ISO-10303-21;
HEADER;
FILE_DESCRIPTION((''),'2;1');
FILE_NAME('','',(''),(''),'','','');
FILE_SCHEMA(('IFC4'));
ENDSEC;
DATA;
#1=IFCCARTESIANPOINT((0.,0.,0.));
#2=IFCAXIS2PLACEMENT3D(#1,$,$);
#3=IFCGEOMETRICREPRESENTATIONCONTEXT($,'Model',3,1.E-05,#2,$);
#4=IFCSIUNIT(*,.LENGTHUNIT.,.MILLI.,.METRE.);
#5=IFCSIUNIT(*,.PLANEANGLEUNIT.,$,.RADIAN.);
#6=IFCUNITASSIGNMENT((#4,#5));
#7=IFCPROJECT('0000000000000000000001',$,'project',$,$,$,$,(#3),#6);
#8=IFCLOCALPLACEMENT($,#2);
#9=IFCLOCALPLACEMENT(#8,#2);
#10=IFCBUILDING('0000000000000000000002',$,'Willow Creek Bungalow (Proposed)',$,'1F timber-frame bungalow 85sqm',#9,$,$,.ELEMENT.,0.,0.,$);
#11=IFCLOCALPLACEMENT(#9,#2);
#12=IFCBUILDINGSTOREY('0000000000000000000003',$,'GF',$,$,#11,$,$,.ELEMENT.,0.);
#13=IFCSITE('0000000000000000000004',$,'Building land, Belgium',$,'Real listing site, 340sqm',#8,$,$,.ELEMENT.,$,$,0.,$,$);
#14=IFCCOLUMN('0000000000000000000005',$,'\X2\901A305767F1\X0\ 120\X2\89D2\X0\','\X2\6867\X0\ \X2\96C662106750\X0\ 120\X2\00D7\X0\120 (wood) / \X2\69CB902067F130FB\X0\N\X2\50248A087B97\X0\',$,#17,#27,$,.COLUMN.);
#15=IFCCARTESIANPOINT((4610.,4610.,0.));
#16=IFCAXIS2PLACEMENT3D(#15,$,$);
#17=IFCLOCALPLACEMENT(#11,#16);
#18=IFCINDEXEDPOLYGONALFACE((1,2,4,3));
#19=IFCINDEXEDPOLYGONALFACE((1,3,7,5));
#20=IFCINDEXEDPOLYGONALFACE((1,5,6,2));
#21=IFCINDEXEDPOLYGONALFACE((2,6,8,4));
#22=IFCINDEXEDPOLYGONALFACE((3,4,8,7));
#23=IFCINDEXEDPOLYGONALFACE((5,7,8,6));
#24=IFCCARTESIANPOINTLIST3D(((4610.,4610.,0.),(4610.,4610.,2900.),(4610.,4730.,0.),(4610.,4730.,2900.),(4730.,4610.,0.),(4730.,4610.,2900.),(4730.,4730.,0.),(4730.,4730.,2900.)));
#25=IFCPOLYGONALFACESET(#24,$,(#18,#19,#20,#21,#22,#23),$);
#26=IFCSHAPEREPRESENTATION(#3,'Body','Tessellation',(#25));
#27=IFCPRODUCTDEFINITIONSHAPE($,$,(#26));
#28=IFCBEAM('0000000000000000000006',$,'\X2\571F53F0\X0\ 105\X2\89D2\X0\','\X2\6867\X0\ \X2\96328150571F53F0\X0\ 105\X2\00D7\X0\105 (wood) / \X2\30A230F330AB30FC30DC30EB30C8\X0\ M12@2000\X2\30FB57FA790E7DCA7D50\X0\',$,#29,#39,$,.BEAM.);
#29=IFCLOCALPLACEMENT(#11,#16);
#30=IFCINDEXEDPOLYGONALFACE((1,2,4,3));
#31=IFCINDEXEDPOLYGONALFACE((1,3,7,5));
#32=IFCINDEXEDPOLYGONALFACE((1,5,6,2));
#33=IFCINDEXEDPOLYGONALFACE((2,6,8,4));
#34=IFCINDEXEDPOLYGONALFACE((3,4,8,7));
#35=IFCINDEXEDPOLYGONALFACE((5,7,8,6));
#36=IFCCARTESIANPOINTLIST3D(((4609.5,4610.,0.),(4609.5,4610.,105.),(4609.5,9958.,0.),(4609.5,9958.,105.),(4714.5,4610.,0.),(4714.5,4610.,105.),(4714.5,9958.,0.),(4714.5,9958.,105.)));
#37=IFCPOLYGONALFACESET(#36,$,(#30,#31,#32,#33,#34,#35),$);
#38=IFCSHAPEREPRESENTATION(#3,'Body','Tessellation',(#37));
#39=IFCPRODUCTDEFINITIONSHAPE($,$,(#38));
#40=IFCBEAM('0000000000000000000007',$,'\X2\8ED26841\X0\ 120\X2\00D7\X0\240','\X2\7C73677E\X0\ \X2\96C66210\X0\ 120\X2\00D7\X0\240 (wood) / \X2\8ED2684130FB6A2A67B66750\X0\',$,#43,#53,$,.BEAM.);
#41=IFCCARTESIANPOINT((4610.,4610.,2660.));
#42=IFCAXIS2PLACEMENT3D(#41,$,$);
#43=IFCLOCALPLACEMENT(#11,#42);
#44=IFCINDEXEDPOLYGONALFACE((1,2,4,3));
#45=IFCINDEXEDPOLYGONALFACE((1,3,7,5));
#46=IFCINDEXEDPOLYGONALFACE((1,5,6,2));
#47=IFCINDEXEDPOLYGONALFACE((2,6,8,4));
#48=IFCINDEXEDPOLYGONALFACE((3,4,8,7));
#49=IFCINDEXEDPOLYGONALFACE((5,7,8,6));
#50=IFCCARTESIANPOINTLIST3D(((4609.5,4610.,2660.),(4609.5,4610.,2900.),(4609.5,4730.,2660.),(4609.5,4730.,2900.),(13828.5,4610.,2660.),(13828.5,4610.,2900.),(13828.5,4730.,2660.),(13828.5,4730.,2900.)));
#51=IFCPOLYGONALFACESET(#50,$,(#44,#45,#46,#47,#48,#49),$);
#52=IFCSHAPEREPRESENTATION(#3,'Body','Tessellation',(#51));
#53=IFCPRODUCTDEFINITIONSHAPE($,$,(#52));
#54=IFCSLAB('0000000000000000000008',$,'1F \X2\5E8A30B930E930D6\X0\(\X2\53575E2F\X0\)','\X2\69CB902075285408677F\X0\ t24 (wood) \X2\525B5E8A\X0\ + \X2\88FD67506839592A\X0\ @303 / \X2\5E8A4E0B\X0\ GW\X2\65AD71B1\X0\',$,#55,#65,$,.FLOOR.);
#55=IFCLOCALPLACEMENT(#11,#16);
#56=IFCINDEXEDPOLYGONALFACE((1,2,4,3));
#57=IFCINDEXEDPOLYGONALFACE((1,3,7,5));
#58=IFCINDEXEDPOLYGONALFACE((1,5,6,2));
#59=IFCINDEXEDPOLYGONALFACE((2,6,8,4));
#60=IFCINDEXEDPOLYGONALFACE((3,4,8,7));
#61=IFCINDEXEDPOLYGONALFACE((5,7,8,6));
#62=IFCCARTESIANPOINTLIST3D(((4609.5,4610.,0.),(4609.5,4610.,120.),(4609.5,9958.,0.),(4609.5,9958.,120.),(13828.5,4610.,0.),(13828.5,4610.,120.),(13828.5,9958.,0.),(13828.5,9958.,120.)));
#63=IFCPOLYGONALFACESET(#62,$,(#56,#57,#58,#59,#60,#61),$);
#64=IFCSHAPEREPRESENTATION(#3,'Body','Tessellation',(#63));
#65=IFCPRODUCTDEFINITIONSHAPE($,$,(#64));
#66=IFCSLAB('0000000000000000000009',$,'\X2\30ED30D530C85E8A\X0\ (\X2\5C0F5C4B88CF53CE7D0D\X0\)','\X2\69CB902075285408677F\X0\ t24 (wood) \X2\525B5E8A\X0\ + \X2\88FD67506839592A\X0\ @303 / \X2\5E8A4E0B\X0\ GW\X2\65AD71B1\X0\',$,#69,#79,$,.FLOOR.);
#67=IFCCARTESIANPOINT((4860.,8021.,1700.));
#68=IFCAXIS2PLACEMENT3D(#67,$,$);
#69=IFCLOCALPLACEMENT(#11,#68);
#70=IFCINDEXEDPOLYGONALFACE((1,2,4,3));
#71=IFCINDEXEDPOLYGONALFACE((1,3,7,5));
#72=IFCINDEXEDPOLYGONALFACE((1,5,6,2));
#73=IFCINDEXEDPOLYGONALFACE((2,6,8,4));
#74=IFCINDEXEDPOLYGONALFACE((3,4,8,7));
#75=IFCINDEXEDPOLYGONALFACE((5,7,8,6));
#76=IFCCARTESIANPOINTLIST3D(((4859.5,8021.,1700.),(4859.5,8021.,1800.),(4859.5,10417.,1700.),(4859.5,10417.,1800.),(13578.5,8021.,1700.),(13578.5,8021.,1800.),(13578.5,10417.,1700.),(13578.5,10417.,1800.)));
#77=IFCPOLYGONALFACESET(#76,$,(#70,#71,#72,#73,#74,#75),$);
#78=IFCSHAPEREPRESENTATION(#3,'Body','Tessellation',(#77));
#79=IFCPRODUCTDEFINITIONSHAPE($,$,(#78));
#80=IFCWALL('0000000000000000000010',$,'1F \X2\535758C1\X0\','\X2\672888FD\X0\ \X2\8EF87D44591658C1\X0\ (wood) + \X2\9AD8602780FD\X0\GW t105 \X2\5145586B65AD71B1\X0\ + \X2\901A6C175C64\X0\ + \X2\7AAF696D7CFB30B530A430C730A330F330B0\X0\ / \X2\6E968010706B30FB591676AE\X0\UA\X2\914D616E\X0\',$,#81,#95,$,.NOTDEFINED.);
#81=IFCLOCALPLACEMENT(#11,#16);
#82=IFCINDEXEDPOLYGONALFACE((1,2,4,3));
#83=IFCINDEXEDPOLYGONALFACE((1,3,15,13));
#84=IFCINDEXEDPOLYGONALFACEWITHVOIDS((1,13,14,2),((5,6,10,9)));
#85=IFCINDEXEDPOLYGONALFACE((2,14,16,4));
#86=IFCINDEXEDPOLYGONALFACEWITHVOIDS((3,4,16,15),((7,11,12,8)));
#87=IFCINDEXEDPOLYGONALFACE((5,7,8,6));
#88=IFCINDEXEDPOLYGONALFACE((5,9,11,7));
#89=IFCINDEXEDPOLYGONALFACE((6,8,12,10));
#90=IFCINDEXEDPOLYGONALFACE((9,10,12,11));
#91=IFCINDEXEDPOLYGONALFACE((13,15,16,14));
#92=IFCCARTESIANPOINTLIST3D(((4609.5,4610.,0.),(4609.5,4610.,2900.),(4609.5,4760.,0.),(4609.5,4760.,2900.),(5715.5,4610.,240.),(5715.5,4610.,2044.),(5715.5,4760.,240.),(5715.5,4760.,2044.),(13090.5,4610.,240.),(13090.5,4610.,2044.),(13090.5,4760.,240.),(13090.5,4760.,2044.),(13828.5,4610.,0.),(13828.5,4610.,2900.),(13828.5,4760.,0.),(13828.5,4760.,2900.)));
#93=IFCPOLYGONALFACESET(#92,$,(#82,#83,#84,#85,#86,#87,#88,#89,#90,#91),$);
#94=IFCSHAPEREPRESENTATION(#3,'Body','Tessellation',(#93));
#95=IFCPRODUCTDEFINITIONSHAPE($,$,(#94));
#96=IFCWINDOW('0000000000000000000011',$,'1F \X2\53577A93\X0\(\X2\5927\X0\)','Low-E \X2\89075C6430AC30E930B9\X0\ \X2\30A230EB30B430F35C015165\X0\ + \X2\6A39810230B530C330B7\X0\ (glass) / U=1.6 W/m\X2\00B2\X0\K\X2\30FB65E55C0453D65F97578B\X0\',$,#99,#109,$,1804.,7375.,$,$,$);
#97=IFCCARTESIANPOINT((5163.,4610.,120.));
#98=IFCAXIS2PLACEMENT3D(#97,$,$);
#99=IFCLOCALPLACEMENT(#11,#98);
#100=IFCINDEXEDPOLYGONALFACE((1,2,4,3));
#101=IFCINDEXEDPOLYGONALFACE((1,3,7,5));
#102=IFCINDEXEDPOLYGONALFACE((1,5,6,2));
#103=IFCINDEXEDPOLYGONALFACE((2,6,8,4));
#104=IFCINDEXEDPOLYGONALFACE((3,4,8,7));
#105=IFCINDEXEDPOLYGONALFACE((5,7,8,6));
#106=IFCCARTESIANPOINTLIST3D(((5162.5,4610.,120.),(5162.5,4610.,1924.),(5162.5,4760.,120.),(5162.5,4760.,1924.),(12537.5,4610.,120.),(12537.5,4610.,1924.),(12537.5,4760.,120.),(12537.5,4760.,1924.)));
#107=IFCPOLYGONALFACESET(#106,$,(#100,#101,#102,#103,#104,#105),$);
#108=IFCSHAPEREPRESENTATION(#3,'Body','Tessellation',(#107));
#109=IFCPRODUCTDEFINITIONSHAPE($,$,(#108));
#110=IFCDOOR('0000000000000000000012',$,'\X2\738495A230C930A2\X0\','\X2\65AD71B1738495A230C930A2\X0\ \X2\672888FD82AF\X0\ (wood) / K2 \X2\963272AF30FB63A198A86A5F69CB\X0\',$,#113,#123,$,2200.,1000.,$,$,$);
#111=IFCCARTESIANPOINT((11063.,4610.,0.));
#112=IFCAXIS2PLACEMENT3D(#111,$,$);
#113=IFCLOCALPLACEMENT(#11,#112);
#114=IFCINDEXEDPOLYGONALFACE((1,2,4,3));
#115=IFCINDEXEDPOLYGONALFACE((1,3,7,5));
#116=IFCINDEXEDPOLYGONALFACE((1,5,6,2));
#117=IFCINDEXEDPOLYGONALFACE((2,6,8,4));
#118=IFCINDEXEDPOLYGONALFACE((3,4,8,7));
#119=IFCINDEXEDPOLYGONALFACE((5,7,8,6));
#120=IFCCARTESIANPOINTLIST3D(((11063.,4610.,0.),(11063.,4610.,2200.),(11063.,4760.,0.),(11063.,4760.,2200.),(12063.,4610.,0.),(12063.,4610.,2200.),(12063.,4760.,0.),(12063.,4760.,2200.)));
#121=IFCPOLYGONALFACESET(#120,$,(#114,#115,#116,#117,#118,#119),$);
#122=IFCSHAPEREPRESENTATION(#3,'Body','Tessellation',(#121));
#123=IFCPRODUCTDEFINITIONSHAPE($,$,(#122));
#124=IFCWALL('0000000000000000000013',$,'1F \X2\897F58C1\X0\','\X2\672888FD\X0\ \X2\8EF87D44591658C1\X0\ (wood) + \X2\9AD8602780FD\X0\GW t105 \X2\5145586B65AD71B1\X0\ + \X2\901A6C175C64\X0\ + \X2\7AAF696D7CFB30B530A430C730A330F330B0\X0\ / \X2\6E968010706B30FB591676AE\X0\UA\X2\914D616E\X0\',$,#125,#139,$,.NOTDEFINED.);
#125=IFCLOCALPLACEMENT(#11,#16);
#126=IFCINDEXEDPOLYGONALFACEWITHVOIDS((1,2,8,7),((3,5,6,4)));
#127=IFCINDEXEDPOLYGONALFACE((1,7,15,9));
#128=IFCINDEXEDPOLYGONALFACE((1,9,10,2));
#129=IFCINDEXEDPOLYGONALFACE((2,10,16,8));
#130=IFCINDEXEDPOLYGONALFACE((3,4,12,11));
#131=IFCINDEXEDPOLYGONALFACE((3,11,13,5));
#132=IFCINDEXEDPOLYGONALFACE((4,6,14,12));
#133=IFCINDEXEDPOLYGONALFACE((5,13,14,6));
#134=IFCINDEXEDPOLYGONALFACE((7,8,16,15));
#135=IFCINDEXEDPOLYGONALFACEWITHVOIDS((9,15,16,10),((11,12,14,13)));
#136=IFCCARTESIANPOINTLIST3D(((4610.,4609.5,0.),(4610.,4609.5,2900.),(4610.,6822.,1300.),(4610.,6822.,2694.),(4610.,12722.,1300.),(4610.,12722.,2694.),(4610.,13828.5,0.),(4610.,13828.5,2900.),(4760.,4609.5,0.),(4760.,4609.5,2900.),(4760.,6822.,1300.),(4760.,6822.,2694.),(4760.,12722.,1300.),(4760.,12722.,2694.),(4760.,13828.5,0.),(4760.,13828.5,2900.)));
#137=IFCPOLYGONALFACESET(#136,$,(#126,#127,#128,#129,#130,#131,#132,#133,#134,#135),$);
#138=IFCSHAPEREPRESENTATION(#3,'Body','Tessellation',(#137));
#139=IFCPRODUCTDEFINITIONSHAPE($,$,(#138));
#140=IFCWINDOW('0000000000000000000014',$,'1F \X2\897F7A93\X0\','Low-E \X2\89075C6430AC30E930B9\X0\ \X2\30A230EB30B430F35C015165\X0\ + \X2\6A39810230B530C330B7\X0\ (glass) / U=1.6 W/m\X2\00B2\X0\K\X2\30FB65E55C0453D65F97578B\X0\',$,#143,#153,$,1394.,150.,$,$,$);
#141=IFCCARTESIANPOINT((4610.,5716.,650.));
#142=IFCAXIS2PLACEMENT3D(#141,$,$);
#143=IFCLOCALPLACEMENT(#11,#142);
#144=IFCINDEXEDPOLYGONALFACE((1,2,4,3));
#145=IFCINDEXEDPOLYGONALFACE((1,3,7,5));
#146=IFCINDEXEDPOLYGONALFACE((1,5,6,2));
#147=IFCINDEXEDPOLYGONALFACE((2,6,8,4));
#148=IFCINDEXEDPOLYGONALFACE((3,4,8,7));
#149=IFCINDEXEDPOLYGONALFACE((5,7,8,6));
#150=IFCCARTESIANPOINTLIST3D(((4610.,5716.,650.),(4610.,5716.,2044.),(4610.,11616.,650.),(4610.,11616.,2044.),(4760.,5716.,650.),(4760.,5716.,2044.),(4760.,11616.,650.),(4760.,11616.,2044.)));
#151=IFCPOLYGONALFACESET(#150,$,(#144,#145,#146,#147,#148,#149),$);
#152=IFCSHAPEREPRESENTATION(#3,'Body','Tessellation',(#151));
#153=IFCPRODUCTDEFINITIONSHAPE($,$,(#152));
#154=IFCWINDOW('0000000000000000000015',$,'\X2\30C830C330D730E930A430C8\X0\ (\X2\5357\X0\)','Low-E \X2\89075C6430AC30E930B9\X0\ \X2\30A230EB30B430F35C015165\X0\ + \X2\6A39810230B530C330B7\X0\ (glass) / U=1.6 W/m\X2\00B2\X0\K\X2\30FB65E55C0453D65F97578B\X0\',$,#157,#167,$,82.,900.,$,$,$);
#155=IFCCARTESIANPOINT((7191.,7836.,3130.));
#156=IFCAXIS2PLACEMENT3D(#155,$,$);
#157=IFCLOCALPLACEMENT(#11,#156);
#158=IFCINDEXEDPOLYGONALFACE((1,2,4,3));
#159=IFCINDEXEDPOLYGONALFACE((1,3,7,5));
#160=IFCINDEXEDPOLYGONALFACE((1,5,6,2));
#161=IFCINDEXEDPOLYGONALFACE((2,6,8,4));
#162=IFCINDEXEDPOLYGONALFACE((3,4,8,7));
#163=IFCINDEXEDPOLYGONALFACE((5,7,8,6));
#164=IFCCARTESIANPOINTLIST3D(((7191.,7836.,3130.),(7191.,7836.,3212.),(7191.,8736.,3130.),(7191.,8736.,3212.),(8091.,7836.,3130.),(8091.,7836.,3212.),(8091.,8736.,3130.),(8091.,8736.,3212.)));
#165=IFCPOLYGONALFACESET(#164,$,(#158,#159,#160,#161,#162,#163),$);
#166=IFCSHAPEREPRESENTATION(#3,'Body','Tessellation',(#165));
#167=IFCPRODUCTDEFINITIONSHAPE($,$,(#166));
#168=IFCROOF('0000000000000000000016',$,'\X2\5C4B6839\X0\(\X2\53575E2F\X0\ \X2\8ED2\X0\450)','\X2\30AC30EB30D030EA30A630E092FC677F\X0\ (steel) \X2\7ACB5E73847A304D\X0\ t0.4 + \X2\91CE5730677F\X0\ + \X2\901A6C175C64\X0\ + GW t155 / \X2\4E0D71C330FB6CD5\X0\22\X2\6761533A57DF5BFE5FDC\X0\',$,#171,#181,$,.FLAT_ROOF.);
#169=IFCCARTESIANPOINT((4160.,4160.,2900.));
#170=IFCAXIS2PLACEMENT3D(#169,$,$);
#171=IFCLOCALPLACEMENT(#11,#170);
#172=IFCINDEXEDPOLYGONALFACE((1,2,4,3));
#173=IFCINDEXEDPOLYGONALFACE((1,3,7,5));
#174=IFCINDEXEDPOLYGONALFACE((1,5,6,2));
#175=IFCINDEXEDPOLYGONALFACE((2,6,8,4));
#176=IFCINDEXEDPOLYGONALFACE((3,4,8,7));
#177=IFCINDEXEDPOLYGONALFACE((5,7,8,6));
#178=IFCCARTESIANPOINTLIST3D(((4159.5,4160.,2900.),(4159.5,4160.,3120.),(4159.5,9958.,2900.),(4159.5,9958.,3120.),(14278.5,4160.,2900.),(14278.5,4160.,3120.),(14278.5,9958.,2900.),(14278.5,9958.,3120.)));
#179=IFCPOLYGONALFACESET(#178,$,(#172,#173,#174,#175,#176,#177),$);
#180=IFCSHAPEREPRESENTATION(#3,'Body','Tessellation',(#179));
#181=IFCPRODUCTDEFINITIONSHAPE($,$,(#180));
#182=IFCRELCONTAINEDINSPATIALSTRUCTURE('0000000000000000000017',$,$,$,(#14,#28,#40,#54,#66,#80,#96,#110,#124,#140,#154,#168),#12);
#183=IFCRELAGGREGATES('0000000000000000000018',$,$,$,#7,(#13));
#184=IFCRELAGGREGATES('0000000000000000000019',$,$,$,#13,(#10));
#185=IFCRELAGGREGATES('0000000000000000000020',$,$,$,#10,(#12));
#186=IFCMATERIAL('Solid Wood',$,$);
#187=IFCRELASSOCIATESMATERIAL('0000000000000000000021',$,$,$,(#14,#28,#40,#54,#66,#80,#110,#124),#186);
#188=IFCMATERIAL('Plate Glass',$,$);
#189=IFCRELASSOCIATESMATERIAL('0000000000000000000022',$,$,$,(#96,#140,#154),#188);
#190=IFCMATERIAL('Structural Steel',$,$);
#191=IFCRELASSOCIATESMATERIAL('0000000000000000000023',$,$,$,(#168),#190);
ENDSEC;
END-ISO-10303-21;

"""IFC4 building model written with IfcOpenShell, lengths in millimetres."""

from ifc_helpers import new_model, si_unit, frame, frame_2d, origin, place, context, project, spatial, rectangle, extrude, material, element, fill, save


model = new_model("IFC4")

# Units and contexts
model_context = context("Model", 3, precision=1e-05, world=origin())
ifc_project = project(units=[si_unit("LENGTHUNIT", "METRE", prefix="MILLI"), si_unit("PLANEANGLEUNIT", "RADIAN")], contexts=[model_context])

# Site, building, storey
site_placement = place(None, origin())
site = spatial("IfcSite", under=ifc_project, at=site_placement, Name="Building land, Belgium", ObjectType="Real listing site, 340sqm", CompositionType="ELEMENT", RefElevation=0.0)
building_placement = place(site_placement, origin())
building = spatial("IfcBuilding", under=site, at=building_placement, Name="Willow Creek Bungalow (Proposed)", ObjectType="1F timber-frame bungalow 85sqm", CompositionType="ELEMENT", ElevationOfRefHeight=0.0, ElevationOfTerrain=0.0)
storey_placement = place(building_placement, origin())
storey = spatial("IfcBuildingStorey", under=building, at=storey_placement, Name="GF", CompositionType="ELEMENT", Elevation=0.0)

# Column
ifc_material_1 = material(Name="Solid Wood")
column_1_placement = place(storey_placement, frame((4610.0, 4610.0, 0.0)))
element("IfcColumn", 1, at=column_1_placement, inside=storey, material=ifc_material_1, Name="通し柱 120角", Description="桧 集成材 120×120 (wood) / 構造柱・N値計算", PredefinedType="COLUMN", context=model_context, shape_type="SweptSolid", body=[
    extrude(rectangle(XDim=120.0, YDim=120.0, at=frame_2d((60.0, 60.0))), frame((4610.0, 4610.0, 0.0)), (0.0, 0.0, 1.0), 2900.0),
])

# Beams
beam_1_placement = place(storey_placement, frame((4610.0, 4610.0, 0.0)))
element("IfcBeam", 2, at=beam_1_placement, inside=storey, material=ifc_material_1, Name="土台 105角", Description="桧 防腐土台 105×105 (wood) / アンカーボルト M12@2000・基礎緊結", PredefinedType="BEAM", context=model_context, shape_type="SweptSolid", body=[
    extrude(rectangle(XDim=105.0, YDim=5348.0, at=frame_2d((52.0, 2674.0))), frame((4610.0, 4610.0, 0.0)), (0.0, 0.0, 1.0), 105.0),
])
beam_2_placement = place(storey_placement, frame((4610.0, 4610.0, 2660.0)))
element("IfcBeam", 3, at=beam_2_placement, inside=storey, material=ifc_material_1, Name="軒桁 120×240", Description="米松 集成 120×240 (wood) / 軒桁・横架材", PredefinedType="BEAM", context=model_context, shape_type="SweptSolid", body=[
    extrude(rectangle(XDim=9219.0, YDim=120.0, at=frame_2d((4609.0, 60.0))), frame((4610.0, 4610.0, 2660.0)), (0.0, 0.0, 1.0), 240.0),
])

# Slabs
slab_1_placement = place(storey_placement, frame((4610.0, 4610.0, 0.0)))
element("IfcSlab", 4, at=slab_1_placement, inside=storey, material=ifc_material_1, Name="1F 床スラブ(南帯)", Description="構造用合板 t24 (wood) 剛床 + 製材根太 @303 / 床下 GW断熱", PredefinedType="FLOOR", context=model_context, shape_type="SweptSolid", body=[
    extrude(rectangle(XDim=9219.0, YDim=5348.0, at=frame_2d((4609.0, 2674.0))), frame((4610.0, 4610.0, 0.0)), (0.0, 0.0, 1.0), 120.0),
])
slab_2_placement = place(storey_placement, frame((4860.0, 8021.0, 1700.0)))
element("IfcSlab", 5, at=slab_2_placement, inside=storey, material=ifc_material_1, Name="ロフト床 (小屋裏収納)", Description="構造用合板 t24 (wood) 剛床 + 製材根太 @303 / 床下 GW断熱", PredefinedType="FLOOR", context=model_context, shape_type="SweptSolid", body=[
    extrude(rectangle(XDim=8719.0, YDim=2396.0, at=frame_2d((4359.0, 1198.0))), frame((4860.0, 8021.0, 1700.0)), (0.0, 0.0, 1.0), 100.0),
])

# Wall, openings, window, door
wall_1_placement = place(storey_placement, frame((4610.0, 4610.0, 0.0)))
wall_1 = element("IfcWall", 6, at=wall_1_placement, inside=storey, material=ifc_material_1, Name="1F 南壁", Description="木製 軸組外壁 (wood) + 高性能GW t105 充填断熱 + 通気層 + 窯業系サイディング / 準耐火・外皮UA配慮", PredefinedType="NOTDEFINED", context=model_context, shape_type="SweptSolid", body=[
    extrude(rectangle(XDim=9219.0, YDim=150.0, at=frame_2d((4609.0, 75.0))), frame((4610.0, 4610.0, 0.0)), (0.0, 0.0, 1.0), 2900.0),
])
opening_1_placement = place(storey_placement, frame((5163.0, 4610.0, 120.0)))
opening_1 = element("IfcOpeningElement", 7, at=opening_1_placement, cuts=wall_1, PredefinedType="NOTDEFINED", context=model_context, shape_type="SweptSolid", body=[
    extrude(rectangle(XDim=7375.0, YDim=150.0, at=frame_2d((3687.0, 75.0))), frame((5163.0, 4610.0, 120.0)), (0.0, 0.0, 1.0), 1804.0),
])
opening_2_placement = place(storey_placement, frame((11063.0, 4610.0, 0.0)))
opening_2 = element("IfcOpeningElement", 8, at=opening_2_placement, cuts=wall_1, PredefinedType="NOTDEFINED", context=model_context, shape_type="SweptSolid", body=[
    extrude(rectangle(XDim=1000.0, YDim=150.0, at=frame_2d((500.0, 75.0))), frame((11063.0, 4610.0, 0.0)), (0.0, 0.0, 1.0), 2200.0),
])
ifc_material_2 = material(Name="Plate Glass")
window_1_placement = place(storey_placement, frame((5163.0, 4610.0, 120.0)))
window_1 = element("IfcWindow", 9, at=window_1_placement, inside=storey, material=ifc_material_2, Name="1F 南窓(大)", Description="Low-E 複層ガラス アルゴン封入 + 樹脂サッシ (glass) / U=1.6 W/m²K・日射取得型", OverallHeight=1804.0, OverallWidth=7375.0, context=model_context, shape_type="SweptSolid", body=[
    extrude(rectangle(XDim=7375.0, YDim=150.0, at=frame_2d((3687.0, 75.0))), frame((5163.0, 4610.0, 120.0)), (0.0, 0.0, 1.0), 1804.0),
])
fill(opening_1, window_1)
door_1_placement = place(storey_placement, frame((11063.0, 4610.0, 0.0)))
door_1 = element("IfcDoor", 10, at=door_1_placement, inside=storey, material=ifc_material_1, Name="玄関ドア", Description="断熱玄関ドア 木製芯 (wood) / K2 防犯・採風機構", OverallHeight=2200.0, OverallWidth=1000.0, context=model_context, shape_type="SweptSolid", body=[
    extrude(rectangle(XDim=1000.0, YDim=150.0, at=frame_2d((500.0, 75.0))), frame((11063.0, 4610.0, 0.0)), (0.0, 0.0, 1.0), 2200.0),
])
fill(opening_2, door_1)

# Wall, opening, window
wall_2_placement = place(storey_placement, frame((4610.0, 4610.0, 0.0)))
wall_2 = element("IfcWall", 11, at=wall_2_placement, inside=storey, material=ifc_material_1, Name="1F 西壁", Description="木製 軸組外壁 (wood) + 高性能GW t105 充填断熱 + 通気層 + 窯業系サイディング / 準耐火・外皮UA配慮", PredefinedType="NOTDEFINED", context=model_context, shape_type="SweptSolid", body=[
    extrude(rectangle(XDim=150.0, YDim=9219.0, at=frame_2d((75.0, 4609.0))), frame((4610.0, 4610.0, 0.0)), (0.0, 0.0, 1.0), 2900.0),
])
opening_3_placement = place(storey_placement, frame((4610.0, 5716.0, 650.0)))
opening_3 = element("IfcOpeningElement", 12, at=opening_3_placement, cuts=wall_2, PredefinedType="NOTDEFINED", context=model_context, shape_type="SweptSolid", body=[
    extrude(rectangle(XDim=150.0, YDim=5900.0, at=frame_2d((75.0, 2950.0))), frame((4610.0, 5716.0, 650.0)), (0.0, 0.0, 1.0), 1394.0),
])
window_2_placement = place(storey_placement, frame((4610.0, 5716.0, 650.0)))
window_2 = element("IfcWindow", 13, at=window_2_placement, inside=storey, material=ifc_material_2, Name="1F 西窓", Description="Low-E 複層ガラス アルゴン封入 + 樹脂サッシ (glass) / U=1.6 W/m²K・日射取得型", OverallHeight=1394.0, OverallWidth=150.0, context=model_context, shape_type="SweptSolid", body=[
    extrude(rectangle(XDim=150.0, YDim=5900.0, at=frame_2d((75.0, 2950.0))), frame((4610.0, 5716.0, 650.0)), (0.0, 0.0, 1.0), 1394.0),
])
fill(opening_3, window_2)

# Window
window_3_placement = place(storey_placement, frame((7191.0, 7836.0, 3130.0)))
element("IfcWindow", 14, at=window_3_placement, inside=storey, material=ifc_material_2, Name="トップライト (南)", Description="Low-E 複層ガラス アルゴン封入 + 樹脂サッシ (glass) / U=1.6 W/m²K・日射取得型", OverallHeight=82.0, OverallWidth=900.0, context=model_context, shape_type="SweptSolid", body=[
    extrude(rectangle(XDim=900.0, YDim=900.0, at=frame_2d((450.0, 450.0))), frame((7191.0, 7836.0, 3130.0)), (0.0, 0.0, 1.0), 82.0),
])

# Roof
ifc_material_3 = material(Name="Structural Steel")
roof_placement = place(storey_placement, frame((4160.0, 4160.0, 2900.0)))
element("IfcRoof", 15, at=roof_placement, inside=storey, material=ifc_material_3, Name="屋根(南帯 軒450)", Description="ガルバリウム鋼板 (steel) 立平葺き t0.4 + 野地板 + 通気層 + GW t155 / 不燃・法22条区域対応", PredefinedType="FLAT_ROOF", context=model_context, shape_type="SweptSolid", body=[
    extrude(rectangle(XDim=10119.0, YDim=5798.0, at=frame_2d((5059.0, 2899.0))), frame((4160.0, 4160.0, 2900.0)), (0.0, 0.0, 1.0), 220.0),
])

save(model, "model.ifc")
